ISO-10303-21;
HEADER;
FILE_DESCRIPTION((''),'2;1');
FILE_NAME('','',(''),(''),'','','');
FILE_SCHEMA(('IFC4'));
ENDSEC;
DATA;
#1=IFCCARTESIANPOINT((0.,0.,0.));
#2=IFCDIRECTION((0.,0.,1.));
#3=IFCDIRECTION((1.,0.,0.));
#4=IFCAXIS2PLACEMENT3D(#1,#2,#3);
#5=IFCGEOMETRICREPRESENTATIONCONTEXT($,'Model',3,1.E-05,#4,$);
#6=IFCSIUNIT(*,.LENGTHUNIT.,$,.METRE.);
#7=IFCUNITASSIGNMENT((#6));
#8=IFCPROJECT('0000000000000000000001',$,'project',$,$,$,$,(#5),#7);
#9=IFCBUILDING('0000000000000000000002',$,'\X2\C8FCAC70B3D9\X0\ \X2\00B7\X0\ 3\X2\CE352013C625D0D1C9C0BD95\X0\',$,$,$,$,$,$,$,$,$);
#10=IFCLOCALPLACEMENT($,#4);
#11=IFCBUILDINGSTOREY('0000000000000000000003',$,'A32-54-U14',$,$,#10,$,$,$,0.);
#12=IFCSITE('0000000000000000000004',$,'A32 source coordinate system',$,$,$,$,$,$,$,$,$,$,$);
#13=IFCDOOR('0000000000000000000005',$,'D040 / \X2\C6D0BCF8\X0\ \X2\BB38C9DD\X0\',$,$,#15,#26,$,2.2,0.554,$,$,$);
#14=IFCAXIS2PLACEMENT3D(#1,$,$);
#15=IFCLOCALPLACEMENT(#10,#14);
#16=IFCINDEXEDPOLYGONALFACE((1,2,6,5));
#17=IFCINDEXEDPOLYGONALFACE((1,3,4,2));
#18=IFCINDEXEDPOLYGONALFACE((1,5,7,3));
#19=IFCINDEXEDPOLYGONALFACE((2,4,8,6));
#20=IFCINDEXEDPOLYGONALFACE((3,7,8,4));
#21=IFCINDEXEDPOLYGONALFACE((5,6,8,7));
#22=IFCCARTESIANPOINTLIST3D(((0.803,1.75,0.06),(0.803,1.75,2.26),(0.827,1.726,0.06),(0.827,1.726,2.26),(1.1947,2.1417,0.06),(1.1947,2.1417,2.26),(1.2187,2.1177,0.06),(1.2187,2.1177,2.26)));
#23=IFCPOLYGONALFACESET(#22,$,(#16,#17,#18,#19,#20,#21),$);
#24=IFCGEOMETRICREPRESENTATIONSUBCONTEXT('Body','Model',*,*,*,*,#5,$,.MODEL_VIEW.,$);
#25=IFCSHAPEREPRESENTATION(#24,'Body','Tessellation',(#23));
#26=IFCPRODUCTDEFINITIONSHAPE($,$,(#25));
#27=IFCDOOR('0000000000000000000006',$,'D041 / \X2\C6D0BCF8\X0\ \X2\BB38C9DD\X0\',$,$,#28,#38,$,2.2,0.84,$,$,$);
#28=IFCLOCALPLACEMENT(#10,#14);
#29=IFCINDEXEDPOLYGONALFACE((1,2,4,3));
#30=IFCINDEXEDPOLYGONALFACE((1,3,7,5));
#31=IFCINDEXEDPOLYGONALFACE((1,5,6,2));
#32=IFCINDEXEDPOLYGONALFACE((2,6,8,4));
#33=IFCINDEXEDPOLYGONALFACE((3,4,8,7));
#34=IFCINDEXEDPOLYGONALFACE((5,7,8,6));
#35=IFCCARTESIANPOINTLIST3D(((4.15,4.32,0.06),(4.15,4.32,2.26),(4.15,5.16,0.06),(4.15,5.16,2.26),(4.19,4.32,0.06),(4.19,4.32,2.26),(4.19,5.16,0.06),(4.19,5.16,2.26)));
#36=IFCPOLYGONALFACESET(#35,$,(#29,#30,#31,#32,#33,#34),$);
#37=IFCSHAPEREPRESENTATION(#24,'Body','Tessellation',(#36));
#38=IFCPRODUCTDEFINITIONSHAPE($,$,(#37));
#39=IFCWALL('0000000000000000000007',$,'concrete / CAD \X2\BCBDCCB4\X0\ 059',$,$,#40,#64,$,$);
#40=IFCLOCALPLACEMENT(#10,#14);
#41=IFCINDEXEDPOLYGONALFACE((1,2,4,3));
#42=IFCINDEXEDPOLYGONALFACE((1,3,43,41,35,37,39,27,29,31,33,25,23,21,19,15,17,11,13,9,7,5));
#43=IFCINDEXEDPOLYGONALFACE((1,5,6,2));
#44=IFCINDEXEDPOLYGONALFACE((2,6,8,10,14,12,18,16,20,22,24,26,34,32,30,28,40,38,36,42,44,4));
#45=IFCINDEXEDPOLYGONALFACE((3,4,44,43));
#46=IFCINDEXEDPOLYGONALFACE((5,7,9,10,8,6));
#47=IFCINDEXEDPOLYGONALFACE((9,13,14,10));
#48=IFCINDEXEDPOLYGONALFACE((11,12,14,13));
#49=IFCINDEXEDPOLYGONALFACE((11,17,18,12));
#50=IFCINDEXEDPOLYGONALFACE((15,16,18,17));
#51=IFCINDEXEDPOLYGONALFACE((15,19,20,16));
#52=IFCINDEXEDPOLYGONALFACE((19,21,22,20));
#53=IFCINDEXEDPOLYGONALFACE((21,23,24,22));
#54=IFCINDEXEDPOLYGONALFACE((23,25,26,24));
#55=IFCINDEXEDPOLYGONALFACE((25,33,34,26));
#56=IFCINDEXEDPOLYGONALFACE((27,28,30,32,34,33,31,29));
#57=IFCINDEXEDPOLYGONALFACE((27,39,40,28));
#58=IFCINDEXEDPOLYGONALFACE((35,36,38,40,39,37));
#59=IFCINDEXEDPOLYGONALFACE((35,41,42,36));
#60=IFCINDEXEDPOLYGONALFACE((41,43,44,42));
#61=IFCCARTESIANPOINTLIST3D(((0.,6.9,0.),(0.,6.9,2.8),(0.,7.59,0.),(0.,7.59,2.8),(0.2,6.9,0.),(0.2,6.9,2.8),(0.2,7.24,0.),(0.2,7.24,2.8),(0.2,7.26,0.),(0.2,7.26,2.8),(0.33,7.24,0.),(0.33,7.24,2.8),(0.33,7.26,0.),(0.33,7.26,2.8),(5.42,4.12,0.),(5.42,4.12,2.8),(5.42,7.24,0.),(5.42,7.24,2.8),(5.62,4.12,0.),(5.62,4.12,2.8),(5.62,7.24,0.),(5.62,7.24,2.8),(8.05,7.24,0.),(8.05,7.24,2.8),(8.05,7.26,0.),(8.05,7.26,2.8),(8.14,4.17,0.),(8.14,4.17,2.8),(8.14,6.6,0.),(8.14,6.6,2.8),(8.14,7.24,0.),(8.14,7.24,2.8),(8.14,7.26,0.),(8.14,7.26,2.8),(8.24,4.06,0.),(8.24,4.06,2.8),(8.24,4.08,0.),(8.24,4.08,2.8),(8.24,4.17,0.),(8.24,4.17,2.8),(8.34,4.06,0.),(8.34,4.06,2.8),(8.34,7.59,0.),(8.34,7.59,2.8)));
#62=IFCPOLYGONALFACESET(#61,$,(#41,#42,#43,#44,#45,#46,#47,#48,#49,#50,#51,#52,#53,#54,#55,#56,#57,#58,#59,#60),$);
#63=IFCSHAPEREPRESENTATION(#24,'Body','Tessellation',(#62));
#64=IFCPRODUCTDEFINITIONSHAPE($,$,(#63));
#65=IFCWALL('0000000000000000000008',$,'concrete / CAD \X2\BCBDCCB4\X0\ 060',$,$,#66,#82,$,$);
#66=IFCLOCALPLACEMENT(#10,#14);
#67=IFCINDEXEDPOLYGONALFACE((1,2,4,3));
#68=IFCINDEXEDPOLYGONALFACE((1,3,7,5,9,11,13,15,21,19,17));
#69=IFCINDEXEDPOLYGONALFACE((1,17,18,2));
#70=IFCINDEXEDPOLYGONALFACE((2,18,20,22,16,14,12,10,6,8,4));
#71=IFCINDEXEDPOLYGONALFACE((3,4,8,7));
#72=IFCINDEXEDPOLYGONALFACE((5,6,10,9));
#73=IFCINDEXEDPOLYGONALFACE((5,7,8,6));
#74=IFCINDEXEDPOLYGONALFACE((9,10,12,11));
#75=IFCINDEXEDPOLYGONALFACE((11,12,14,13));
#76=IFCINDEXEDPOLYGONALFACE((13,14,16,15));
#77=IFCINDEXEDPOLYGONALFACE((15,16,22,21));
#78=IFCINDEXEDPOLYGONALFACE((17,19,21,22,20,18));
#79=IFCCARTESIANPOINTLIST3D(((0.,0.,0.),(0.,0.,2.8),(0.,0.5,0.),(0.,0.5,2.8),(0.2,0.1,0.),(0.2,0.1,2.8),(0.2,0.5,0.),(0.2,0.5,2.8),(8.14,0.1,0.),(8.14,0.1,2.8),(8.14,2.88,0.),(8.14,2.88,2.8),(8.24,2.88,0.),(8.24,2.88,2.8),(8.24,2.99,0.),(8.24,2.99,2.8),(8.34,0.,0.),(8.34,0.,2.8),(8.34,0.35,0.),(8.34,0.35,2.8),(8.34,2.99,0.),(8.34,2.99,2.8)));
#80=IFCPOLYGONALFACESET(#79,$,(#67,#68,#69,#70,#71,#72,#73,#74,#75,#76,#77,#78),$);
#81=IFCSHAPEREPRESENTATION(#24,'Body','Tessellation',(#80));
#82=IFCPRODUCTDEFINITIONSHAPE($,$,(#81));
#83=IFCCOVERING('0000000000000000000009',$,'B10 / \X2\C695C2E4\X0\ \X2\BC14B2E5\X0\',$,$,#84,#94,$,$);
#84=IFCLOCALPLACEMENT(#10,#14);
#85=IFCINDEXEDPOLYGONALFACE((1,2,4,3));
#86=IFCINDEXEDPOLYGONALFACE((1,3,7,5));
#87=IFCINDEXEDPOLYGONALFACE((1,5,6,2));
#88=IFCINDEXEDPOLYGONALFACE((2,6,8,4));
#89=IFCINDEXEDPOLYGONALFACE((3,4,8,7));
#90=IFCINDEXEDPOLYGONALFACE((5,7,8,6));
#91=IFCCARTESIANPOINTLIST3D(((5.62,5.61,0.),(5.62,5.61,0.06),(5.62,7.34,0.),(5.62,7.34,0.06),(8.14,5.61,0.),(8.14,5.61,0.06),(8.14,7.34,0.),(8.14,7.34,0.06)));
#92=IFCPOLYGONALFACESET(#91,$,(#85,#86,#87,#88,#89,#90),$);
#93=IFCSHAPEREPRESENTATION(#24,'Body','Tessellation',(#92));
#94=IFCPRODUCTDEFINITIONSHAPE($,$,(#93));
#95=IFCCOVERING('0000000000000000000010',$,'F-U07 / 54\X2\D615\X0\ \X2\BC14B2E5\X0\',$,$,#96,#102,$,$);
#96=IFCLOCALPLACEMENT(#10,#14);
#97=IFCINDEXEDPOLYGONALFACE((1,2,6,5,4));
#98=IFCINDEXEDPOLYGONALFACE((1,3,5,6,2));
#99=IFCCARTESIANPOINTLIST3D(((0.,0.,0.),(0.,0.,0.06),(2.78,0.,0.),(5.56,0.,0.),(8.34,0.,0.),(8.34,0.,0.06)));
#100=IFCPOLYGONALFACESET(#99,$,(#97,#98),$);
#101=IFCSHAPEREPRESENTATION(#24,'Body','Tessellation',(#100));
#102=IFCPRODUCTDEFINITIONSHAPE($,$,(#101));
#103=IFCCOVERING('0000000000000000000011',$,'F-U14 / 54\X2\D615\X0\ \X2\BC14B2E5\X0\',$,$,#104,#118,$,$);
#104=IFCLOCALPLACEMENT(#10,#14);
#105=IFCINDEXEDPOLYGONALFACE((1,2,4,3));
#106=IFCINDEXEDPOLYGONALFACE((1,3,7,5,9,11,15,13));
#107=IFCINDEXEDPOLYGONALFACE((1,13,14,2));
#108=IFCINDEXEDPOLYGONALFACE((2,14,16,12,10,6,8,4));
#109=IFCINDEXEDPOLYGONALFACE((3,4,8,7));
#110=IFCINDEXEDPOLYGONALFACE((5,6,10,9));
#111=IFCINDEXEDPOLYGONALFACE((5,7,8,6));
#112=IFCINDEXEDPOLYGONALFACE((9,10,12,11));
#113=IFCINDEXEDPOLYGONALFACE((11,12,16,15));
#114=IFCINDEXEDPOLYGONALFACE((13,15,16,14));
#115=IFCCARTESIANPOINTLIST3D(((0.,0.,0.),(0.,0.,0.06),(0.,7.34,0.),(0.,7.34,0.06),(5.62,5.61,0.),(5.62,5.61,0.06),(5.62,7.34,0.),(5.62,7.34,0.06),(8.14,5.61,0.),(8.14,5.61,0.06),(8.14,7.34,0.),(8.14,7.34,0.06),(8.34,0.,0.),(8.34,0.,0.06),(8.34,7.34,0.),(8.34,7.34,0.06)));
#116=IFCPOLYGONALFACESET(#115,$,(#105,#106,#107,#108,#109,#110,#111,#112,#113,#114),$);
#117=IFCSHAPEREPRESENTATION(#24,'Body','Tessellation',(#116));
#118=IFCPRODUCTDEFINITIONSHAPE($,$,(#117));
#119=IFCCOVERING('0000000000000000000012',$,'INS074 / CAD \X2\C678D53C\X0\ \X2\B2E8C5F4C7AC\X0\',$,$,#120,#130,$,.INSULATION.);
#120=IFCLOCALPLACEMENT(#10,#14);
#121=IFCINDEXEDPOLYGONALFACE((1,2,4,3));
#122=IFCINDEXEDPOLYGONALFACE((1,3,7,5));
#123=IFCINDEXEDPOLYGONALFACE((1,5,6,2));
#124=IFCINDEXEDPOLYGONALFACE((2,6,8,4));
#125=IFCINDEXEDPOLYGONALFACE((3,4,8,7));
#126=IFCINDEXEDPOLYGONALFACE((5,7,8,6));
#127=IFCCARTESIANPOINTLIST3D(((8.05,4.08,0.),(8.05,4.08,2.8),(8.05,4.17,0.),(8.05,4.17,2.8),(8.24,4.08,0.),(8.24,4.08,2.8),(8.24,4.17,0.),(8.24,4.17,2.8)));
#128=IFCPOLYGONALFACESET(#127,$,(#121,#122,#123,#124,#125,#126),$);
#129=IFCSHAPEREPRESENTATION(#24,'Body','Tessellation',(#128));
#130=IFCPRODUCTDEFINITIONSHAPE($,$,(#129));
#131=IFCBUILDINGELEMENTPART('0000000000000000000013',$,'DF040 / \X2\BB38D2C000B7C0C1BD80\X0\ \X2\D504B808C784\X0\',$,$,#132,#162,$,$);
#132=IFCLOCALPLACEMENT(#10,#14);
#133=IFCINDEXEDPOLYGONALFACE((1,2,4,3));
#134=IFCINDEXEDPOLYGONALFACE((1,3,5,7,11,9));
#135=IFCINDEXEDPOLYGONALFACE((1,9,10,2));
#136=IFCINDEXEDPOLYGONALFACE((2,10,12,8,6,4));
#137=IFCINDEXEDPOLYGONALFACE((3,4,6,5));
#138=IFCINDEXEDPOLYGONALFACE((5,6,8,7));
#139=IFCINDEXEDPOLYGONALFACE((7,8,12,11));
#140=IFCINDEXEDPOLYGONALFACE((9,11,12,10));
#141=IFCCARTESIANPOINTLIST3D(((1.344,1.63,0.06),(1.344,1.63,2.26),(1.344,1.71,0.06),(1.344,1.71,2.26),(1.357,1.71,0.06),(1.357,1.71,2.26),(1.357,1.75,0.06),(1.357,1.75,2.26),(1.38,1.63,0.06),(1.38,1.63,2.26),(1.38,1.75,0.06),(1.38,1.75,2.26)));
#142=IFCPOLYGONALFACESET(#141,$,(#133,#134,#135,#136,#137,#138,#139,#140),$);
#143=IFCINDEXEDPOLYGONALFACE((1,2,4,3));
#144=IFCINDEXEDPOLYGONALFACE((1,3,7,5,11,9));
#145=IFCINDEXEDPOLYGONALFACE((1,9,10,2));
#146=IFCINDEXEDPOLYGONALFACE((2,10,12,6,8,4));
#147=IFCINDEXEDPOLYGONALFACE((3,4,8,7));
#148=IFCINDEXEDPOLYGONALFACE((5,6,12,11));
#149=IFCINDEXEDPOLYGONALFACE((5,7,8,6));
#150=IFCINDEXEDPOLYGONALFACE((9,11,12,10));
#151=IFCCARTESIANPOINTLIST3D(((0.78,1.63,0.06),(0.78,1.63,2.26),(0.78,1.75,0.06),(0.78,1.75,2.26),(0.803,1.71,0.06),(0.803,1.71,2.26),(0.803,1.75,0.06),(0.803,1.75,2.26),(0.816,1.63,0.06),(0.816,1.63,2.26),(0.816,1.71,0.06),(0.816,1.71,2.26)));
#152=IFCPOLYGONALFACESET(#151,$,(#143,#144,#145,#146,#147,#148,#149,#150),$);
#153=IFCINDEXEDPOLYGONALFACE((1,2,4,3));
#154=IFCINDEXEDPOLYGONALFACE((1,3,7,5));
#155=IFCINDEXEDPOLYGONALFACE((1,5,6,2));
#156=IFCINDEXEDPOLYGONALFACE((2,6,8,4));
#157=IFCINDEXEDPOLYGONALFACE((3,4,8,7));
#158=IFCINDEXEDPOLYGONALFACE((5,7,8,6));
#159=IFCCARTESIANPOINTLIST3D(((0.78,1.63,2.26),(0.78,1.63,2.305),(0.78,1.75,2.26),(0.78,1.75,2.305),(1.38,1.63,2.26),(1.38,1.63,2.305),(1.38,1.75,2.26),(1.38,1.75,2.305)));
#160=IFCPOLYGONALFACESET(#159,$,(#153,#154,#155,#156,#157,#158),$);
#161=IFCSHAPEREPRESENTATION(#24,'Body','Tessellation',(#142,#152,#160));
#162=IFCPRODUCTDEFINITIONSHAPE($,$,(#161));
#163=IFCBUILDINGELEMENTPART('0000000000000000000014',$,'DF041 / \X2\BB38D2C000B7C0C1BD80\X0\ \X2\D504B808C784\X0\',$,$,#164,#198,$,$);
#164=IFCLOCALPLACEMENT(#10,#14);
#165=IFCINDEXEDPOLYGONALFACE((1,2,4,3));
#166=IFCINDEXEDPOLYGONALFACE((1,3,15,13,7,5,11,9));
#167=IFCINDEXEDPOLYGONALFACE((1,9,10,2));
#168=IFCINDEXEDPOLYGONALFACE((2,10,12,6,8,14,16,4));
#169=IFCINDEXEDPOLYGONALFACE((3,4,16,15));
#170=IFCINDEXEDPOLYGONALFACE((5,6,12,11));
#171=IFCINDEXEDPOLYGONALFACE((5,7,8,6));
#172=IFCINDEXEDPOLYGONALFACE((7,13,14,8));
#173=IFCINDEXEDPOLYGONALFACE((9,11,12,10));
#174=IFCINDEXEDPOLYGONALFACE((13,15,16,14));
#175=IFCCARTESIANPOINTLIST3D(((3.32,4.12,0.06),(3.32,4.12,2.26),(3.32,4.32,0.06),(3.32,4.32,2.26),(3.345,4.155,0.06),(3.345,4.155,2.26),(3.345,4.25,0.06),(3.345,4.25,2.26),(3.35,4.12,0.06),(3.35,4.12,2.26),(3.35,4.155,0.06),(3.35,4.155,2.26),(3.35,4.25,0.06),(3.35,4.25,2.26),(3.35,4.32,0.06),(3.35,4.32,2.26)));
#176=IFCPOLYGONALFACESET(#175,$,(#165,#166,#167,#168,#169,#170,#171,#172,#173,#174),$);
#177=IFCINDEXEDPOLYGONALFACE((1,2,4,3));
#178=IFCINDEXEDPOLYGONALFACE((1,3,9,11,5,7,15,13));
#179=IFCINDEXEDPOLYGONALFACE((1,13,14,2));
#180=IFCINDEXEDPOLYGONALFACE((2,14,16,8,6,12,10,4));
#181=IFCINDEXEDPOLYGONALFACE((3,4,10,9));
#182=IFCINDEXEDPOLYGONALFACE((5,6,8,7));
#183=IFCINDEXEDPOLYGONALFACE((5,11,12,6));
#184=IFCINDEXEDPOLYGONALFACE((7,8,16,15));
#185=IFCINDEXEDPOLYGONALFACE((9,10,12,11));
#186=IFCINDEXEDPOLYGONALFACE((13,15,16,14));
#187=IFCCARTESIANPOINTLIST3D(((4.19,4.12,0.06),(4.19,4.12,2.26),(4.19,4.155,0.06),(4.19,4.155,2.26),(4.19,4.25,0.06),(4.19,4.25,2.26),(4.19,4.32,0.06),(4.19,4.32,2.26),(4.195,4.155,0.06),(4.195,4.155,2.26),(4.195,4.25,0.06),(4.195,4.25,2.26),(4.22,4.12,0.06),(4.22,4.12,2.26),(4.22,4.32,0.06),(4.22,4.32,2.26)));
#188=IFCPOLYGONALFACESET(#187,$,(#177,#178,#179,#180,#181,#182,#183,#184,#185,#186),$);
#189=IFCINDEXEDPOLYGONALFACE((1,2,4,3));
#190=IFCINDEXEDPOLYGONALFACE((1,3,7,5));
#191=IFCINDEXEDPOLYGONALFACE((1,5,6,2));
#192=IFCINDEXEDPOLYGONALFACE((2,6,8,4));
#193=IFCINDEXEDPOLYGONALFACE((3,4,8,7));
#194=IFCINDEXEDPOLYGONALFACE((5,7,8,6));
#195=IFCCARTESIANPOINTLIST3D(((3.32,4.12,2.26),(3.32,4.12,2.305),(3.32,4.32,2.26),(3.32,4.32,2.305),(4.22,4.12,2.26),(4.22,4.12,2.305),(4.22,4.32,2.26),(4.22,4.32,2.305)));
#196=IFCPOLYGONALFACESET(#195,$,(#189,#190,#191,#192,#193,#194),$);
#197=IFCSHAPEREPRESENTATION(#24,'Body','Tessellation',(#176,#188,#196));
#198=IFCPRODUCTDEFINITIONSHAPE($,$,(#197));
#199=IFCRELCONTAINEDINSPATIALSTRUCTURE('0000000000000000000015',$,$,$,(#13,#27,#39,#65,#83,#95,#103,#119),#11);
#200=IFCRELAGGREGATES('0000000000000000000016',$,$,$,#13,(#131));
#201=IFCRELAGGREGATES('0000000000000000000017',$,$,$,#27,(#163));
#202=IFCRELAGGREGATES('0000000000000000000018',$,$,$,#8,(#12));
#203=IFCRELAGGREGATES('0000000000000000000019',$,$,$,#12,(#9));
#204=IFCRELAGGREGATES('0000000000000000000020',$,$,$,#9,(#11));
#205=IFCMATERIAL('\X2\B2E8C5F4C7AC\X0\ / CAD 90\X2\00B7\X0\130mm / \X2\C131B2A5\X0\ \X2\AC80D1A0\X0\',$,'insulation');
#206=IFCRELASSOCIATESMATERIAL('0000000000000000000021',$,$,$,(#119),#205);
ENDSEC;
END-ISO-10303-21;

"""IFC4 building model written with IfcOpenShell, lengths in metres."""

from ifc_helpers import new_model, si_unit, frame, origin, origin_with_axes, place, context, subcontext, project, spatial, polyline, outline, extrude, material, element, aggregate, save


model = new_model("IFC4")

# Units and contexts
model_context = context("Model", 3, precision=1e-05, world=origin_with_axes())
body_context = subcontext(model_context, "Body", "Model", "MODEL_VIEW")
ifc_project = project(units=[si_unit("LENGTHUNIT", "METRE")], contexts=[model_context])

# Site, building, storey
storey_placement = place(None, origin_with_axes())
site = spatial("IfcSite", under=ifc_project, Name="A32 source coordinate system")
building = spatial("IfcBuilding", under=site, Name="주거동 · 3층–옥탑지붕")
storey = spatial("IfcBuildingStorey", under=building, at=storey_placement, Name="A32-54-U14", Elevation=0.0)

# Doors
door_1_placement = place(storey_placement, origin_with_axes())
door_1 = element("IfcDoor", 1, at=door_1_placement, inside=storey, Name="D040 / 원본 문짝", OverallHeight=2.2, OverallWidth=0.554, context=body_context, shape_type="SweptSolid", body=[
    extrude(outline(polyline([(0.803, 1.75), (1.1947, 2.1417), (1.2187, 2.1177), (0.827, 1.726), (0.803, 1.75)])), frame((0.0, 0.0, 0.06)), (0.0, 0.0, 1.0), 2.2),
])
door_2_placement = place(storey_placement, origin_with_axes())
door_2 = element("IfcDoor", 2, at=door_2_placement, inside=storey, Name="D041 / 원본 문짝", OverallHeight=2.2, OverallWidth=0.84, context=body_context, shape_type="SweptSolid", body=[
    extrude(outline(polyline([(4.15, 5.16), (4.19, 5.16), (4.19, 4.32), (4.15, 4.32), (4.15, 5.16)])), frame((0.0, 0.0, 0.06)), (0.0, 0.0, 1.0), 2.2),
])

# Walls
wall_1_placement = place(storey_placement, origin_with_axes())
element("IfcWall", 3, at=wall_1_placement, inside=storey, Name="concrete / CAD 벽체 059", context=body_context, shape_type="SweptSolid", body=[
    extrude(outline(polyline([(8.05, 7.26), (8.05, 7.24), (5.62, 7.24), (5.62, 4.12), (5.42, 4.12), (5.42, 7.24), (0.33, 7.24), (0.33, 7.26), (0.2, 7.26), (0.2, 7.24), (0.2, 6.9), (0.0, 6.9), (0.0, 7.59), (8.34, 7.59), (8.34, 4.06), (8.24, 4.06), (8.24, 4.08), (8.24, 4.17), (8.14, 4.17), (8.14, 6.6), (8.14, 7.24), (8.14, 7.26), (8.05, 7.26)])), origin(), (0.0, 0.0, 1.0), 2.8),
])
wall_2_placement = place(storey_placement, origin_with_axes())
element("IfcWall", 4, at=wall_2_placement, inside=storey, Name="concrete / CAD 벽체 060", context=body_context, shape_type="SweptSolid", body=[
    extrude(outline(polyline([(0.2, 0.5), (0.2, 0.1), (8.14, 0.1), (8.14, 2.88), (8.24, 2.88), (8.24, 2.99), (8.34, 2.99), (8.34, 0.35), (8.34, 0.35), (8.34, 0.0), (0.0, 0.0), (0.0, 0.5), (0.2, 0.5)])), origin(), (0.0, 0.0, 1.0), 2.8),
])

# Coverings
covering_1_placement = place(storey_placement, origin_with_axes())
element("IfcCovering", 5, at=covering_1_placement, inside=storey, Name="B10 / 욕실 바닥", context=body_context, shape_type="SweptSolid", body=[
    extrude(outline(polyline([(8.14, 5.61), (5.62, 5.61), (5.62, 7.34), (8.14, 7.34), (8.14, 5.61)])), origin(), (0.0, 0.0, 1.0), 0.06),
])
covering_2_placement = place(storey_placement, origin_with_axes())
element("IfcCovering", 6, at=covering_2_placement, inside=storey, Name="F-U07 / 54형 바닥", context=body_context, shape_type="SweptSolid", body=[
    extrude(outline(polyline([(0.0, 0.0), (0.0, 0.0), (8.34, 0.0), (8.34, 0.0), (0.0, 0.0)])), origin(), (0.0, 0.0, 1.0), 0.06),
])
covering_3_placement = place(storey_placement, origin_with_axes())
element("IfcCovering", 7, at=covering_3_placement, inside=storey, Name="F-U14 / 54형 바닥", context=body_context, shape_type="SweptSolid", body=[
    extrude(outline(polyline([(8.14, 7.34), (8.34, 7.34), (8.34, 0.0), (0.0, 0.0), (0.0, 7.34), (5.62, 7.34), (5.62, 5.61), (8.14, 5.61), (8.14, 7.34)])), origin(), (0.0, 0.0, 1.0), 0.06),
])
ifc_material = material(Name="단열재 / CAD 90·130mm / 성능 검토", Category="insulation")
covering_4_placement = place(storey_placement, origin_with_axes())
element("IfcCovering", 8, at=covering_4_placement, inside=storey, material=ifc_material, Name="INS074 / CAD 외피 단열재", PredefinedType="INSULATION", context=body_context, shape_type="SweptSolid", body=[
    extrude(outline(polyline([(8.05, 4.08), (8.05, 4.17), (8.24, 4.17), (8.24, 4.08), (8.05, 4.08)])), origin(), (0.0, 0.0, 1.0), 2.8),
])

# Building element parts
building_element_part_1_placement = place(door_1_placement, origin_with_axes())
building_element_part_1 = element("IfcBuildingElementPart", 9, at=building_element_part_1_placement, Name="DF040 / 문틀·상부 프레임", context=body_context, shape_type="SweptSolid", body=[
    extrude(outline(polyline([(1.344, 1.63), (1.344, 1.71), (1.357, 1.71), (1.357, 1.75), (1.38, 1.75), (1.38, 1.63), (1.344, 1.63)])), frame((0.0, 0.0, 0.06)), (0.0, 0.0, 1.0), 2.2),
    extrude(outline(polyline([(0.78, 1.75), (0.803, 1.75), (0.803, 1.71), (0.816, 1.71), (0.816, 1.63), (0.78, 1.63), (0.78, 1.75)])), frame((0.0, 0.0, 0.06)), (0.0, 0.0, 1.0), 2.2),
    extrude(outline(polyline([(0.78, 1.63), (0.78, 1.75), (1.38, 1.75), (1.38, 1.63), (0.78, 1.63)])), frame((0.0, 0.0, 2.26)), (0.0, 0.0, 1.0), 0.045),
])
aggregate(door_1, [building_element_part_1])
building_element_part_2_placement = place(door_2_placement, origin_with_axes())
building_element_part_2 = element("IfcBuildingElementPart", 10, at=building_element_part_2_placement, Name="DF041 / 문틀·상부 프레임", context=body_context, shape_type="SweptSolid", body=[
    extrude(outline(polyline([(3.35, 4.32), (3.35, 4.25), (3.345, 4.25), (3.345, 4.155), (3.35, 4.155), (3.35, 4.12), (3.32, 4.12), (3.32, 4.32), (3.35, 4.32)])), frame((0.0, 0.0, 0.06)), (0.0, 0.0, 1.0), 2.2),
    extrude(outline(polyline([(4.22, 4.12), (4.19, 4.12), (4.19, 4.155), (4.195, 4.155), (4.195, 4.25), (4.19, 4.25), (4.19, 4.32), (4.22, 4.32), (4.22, 4.12)])), frame((0.0, 0.0, 0.06)), (0.0, 0.0, 1.0), 2.2),
    extrude(outline(polyline([(3.32, 4.12), (3.32, 4.32), (4.22, 4.32), (4.22, 4.12), (3.32, 4.12)])), frame((0.0, 0.0, 2.26)), (0.0, 0.0, 1.0), 0.045),
])
aggregate(door_2, [building_element_part_2])

save(model, "model.ifc")
